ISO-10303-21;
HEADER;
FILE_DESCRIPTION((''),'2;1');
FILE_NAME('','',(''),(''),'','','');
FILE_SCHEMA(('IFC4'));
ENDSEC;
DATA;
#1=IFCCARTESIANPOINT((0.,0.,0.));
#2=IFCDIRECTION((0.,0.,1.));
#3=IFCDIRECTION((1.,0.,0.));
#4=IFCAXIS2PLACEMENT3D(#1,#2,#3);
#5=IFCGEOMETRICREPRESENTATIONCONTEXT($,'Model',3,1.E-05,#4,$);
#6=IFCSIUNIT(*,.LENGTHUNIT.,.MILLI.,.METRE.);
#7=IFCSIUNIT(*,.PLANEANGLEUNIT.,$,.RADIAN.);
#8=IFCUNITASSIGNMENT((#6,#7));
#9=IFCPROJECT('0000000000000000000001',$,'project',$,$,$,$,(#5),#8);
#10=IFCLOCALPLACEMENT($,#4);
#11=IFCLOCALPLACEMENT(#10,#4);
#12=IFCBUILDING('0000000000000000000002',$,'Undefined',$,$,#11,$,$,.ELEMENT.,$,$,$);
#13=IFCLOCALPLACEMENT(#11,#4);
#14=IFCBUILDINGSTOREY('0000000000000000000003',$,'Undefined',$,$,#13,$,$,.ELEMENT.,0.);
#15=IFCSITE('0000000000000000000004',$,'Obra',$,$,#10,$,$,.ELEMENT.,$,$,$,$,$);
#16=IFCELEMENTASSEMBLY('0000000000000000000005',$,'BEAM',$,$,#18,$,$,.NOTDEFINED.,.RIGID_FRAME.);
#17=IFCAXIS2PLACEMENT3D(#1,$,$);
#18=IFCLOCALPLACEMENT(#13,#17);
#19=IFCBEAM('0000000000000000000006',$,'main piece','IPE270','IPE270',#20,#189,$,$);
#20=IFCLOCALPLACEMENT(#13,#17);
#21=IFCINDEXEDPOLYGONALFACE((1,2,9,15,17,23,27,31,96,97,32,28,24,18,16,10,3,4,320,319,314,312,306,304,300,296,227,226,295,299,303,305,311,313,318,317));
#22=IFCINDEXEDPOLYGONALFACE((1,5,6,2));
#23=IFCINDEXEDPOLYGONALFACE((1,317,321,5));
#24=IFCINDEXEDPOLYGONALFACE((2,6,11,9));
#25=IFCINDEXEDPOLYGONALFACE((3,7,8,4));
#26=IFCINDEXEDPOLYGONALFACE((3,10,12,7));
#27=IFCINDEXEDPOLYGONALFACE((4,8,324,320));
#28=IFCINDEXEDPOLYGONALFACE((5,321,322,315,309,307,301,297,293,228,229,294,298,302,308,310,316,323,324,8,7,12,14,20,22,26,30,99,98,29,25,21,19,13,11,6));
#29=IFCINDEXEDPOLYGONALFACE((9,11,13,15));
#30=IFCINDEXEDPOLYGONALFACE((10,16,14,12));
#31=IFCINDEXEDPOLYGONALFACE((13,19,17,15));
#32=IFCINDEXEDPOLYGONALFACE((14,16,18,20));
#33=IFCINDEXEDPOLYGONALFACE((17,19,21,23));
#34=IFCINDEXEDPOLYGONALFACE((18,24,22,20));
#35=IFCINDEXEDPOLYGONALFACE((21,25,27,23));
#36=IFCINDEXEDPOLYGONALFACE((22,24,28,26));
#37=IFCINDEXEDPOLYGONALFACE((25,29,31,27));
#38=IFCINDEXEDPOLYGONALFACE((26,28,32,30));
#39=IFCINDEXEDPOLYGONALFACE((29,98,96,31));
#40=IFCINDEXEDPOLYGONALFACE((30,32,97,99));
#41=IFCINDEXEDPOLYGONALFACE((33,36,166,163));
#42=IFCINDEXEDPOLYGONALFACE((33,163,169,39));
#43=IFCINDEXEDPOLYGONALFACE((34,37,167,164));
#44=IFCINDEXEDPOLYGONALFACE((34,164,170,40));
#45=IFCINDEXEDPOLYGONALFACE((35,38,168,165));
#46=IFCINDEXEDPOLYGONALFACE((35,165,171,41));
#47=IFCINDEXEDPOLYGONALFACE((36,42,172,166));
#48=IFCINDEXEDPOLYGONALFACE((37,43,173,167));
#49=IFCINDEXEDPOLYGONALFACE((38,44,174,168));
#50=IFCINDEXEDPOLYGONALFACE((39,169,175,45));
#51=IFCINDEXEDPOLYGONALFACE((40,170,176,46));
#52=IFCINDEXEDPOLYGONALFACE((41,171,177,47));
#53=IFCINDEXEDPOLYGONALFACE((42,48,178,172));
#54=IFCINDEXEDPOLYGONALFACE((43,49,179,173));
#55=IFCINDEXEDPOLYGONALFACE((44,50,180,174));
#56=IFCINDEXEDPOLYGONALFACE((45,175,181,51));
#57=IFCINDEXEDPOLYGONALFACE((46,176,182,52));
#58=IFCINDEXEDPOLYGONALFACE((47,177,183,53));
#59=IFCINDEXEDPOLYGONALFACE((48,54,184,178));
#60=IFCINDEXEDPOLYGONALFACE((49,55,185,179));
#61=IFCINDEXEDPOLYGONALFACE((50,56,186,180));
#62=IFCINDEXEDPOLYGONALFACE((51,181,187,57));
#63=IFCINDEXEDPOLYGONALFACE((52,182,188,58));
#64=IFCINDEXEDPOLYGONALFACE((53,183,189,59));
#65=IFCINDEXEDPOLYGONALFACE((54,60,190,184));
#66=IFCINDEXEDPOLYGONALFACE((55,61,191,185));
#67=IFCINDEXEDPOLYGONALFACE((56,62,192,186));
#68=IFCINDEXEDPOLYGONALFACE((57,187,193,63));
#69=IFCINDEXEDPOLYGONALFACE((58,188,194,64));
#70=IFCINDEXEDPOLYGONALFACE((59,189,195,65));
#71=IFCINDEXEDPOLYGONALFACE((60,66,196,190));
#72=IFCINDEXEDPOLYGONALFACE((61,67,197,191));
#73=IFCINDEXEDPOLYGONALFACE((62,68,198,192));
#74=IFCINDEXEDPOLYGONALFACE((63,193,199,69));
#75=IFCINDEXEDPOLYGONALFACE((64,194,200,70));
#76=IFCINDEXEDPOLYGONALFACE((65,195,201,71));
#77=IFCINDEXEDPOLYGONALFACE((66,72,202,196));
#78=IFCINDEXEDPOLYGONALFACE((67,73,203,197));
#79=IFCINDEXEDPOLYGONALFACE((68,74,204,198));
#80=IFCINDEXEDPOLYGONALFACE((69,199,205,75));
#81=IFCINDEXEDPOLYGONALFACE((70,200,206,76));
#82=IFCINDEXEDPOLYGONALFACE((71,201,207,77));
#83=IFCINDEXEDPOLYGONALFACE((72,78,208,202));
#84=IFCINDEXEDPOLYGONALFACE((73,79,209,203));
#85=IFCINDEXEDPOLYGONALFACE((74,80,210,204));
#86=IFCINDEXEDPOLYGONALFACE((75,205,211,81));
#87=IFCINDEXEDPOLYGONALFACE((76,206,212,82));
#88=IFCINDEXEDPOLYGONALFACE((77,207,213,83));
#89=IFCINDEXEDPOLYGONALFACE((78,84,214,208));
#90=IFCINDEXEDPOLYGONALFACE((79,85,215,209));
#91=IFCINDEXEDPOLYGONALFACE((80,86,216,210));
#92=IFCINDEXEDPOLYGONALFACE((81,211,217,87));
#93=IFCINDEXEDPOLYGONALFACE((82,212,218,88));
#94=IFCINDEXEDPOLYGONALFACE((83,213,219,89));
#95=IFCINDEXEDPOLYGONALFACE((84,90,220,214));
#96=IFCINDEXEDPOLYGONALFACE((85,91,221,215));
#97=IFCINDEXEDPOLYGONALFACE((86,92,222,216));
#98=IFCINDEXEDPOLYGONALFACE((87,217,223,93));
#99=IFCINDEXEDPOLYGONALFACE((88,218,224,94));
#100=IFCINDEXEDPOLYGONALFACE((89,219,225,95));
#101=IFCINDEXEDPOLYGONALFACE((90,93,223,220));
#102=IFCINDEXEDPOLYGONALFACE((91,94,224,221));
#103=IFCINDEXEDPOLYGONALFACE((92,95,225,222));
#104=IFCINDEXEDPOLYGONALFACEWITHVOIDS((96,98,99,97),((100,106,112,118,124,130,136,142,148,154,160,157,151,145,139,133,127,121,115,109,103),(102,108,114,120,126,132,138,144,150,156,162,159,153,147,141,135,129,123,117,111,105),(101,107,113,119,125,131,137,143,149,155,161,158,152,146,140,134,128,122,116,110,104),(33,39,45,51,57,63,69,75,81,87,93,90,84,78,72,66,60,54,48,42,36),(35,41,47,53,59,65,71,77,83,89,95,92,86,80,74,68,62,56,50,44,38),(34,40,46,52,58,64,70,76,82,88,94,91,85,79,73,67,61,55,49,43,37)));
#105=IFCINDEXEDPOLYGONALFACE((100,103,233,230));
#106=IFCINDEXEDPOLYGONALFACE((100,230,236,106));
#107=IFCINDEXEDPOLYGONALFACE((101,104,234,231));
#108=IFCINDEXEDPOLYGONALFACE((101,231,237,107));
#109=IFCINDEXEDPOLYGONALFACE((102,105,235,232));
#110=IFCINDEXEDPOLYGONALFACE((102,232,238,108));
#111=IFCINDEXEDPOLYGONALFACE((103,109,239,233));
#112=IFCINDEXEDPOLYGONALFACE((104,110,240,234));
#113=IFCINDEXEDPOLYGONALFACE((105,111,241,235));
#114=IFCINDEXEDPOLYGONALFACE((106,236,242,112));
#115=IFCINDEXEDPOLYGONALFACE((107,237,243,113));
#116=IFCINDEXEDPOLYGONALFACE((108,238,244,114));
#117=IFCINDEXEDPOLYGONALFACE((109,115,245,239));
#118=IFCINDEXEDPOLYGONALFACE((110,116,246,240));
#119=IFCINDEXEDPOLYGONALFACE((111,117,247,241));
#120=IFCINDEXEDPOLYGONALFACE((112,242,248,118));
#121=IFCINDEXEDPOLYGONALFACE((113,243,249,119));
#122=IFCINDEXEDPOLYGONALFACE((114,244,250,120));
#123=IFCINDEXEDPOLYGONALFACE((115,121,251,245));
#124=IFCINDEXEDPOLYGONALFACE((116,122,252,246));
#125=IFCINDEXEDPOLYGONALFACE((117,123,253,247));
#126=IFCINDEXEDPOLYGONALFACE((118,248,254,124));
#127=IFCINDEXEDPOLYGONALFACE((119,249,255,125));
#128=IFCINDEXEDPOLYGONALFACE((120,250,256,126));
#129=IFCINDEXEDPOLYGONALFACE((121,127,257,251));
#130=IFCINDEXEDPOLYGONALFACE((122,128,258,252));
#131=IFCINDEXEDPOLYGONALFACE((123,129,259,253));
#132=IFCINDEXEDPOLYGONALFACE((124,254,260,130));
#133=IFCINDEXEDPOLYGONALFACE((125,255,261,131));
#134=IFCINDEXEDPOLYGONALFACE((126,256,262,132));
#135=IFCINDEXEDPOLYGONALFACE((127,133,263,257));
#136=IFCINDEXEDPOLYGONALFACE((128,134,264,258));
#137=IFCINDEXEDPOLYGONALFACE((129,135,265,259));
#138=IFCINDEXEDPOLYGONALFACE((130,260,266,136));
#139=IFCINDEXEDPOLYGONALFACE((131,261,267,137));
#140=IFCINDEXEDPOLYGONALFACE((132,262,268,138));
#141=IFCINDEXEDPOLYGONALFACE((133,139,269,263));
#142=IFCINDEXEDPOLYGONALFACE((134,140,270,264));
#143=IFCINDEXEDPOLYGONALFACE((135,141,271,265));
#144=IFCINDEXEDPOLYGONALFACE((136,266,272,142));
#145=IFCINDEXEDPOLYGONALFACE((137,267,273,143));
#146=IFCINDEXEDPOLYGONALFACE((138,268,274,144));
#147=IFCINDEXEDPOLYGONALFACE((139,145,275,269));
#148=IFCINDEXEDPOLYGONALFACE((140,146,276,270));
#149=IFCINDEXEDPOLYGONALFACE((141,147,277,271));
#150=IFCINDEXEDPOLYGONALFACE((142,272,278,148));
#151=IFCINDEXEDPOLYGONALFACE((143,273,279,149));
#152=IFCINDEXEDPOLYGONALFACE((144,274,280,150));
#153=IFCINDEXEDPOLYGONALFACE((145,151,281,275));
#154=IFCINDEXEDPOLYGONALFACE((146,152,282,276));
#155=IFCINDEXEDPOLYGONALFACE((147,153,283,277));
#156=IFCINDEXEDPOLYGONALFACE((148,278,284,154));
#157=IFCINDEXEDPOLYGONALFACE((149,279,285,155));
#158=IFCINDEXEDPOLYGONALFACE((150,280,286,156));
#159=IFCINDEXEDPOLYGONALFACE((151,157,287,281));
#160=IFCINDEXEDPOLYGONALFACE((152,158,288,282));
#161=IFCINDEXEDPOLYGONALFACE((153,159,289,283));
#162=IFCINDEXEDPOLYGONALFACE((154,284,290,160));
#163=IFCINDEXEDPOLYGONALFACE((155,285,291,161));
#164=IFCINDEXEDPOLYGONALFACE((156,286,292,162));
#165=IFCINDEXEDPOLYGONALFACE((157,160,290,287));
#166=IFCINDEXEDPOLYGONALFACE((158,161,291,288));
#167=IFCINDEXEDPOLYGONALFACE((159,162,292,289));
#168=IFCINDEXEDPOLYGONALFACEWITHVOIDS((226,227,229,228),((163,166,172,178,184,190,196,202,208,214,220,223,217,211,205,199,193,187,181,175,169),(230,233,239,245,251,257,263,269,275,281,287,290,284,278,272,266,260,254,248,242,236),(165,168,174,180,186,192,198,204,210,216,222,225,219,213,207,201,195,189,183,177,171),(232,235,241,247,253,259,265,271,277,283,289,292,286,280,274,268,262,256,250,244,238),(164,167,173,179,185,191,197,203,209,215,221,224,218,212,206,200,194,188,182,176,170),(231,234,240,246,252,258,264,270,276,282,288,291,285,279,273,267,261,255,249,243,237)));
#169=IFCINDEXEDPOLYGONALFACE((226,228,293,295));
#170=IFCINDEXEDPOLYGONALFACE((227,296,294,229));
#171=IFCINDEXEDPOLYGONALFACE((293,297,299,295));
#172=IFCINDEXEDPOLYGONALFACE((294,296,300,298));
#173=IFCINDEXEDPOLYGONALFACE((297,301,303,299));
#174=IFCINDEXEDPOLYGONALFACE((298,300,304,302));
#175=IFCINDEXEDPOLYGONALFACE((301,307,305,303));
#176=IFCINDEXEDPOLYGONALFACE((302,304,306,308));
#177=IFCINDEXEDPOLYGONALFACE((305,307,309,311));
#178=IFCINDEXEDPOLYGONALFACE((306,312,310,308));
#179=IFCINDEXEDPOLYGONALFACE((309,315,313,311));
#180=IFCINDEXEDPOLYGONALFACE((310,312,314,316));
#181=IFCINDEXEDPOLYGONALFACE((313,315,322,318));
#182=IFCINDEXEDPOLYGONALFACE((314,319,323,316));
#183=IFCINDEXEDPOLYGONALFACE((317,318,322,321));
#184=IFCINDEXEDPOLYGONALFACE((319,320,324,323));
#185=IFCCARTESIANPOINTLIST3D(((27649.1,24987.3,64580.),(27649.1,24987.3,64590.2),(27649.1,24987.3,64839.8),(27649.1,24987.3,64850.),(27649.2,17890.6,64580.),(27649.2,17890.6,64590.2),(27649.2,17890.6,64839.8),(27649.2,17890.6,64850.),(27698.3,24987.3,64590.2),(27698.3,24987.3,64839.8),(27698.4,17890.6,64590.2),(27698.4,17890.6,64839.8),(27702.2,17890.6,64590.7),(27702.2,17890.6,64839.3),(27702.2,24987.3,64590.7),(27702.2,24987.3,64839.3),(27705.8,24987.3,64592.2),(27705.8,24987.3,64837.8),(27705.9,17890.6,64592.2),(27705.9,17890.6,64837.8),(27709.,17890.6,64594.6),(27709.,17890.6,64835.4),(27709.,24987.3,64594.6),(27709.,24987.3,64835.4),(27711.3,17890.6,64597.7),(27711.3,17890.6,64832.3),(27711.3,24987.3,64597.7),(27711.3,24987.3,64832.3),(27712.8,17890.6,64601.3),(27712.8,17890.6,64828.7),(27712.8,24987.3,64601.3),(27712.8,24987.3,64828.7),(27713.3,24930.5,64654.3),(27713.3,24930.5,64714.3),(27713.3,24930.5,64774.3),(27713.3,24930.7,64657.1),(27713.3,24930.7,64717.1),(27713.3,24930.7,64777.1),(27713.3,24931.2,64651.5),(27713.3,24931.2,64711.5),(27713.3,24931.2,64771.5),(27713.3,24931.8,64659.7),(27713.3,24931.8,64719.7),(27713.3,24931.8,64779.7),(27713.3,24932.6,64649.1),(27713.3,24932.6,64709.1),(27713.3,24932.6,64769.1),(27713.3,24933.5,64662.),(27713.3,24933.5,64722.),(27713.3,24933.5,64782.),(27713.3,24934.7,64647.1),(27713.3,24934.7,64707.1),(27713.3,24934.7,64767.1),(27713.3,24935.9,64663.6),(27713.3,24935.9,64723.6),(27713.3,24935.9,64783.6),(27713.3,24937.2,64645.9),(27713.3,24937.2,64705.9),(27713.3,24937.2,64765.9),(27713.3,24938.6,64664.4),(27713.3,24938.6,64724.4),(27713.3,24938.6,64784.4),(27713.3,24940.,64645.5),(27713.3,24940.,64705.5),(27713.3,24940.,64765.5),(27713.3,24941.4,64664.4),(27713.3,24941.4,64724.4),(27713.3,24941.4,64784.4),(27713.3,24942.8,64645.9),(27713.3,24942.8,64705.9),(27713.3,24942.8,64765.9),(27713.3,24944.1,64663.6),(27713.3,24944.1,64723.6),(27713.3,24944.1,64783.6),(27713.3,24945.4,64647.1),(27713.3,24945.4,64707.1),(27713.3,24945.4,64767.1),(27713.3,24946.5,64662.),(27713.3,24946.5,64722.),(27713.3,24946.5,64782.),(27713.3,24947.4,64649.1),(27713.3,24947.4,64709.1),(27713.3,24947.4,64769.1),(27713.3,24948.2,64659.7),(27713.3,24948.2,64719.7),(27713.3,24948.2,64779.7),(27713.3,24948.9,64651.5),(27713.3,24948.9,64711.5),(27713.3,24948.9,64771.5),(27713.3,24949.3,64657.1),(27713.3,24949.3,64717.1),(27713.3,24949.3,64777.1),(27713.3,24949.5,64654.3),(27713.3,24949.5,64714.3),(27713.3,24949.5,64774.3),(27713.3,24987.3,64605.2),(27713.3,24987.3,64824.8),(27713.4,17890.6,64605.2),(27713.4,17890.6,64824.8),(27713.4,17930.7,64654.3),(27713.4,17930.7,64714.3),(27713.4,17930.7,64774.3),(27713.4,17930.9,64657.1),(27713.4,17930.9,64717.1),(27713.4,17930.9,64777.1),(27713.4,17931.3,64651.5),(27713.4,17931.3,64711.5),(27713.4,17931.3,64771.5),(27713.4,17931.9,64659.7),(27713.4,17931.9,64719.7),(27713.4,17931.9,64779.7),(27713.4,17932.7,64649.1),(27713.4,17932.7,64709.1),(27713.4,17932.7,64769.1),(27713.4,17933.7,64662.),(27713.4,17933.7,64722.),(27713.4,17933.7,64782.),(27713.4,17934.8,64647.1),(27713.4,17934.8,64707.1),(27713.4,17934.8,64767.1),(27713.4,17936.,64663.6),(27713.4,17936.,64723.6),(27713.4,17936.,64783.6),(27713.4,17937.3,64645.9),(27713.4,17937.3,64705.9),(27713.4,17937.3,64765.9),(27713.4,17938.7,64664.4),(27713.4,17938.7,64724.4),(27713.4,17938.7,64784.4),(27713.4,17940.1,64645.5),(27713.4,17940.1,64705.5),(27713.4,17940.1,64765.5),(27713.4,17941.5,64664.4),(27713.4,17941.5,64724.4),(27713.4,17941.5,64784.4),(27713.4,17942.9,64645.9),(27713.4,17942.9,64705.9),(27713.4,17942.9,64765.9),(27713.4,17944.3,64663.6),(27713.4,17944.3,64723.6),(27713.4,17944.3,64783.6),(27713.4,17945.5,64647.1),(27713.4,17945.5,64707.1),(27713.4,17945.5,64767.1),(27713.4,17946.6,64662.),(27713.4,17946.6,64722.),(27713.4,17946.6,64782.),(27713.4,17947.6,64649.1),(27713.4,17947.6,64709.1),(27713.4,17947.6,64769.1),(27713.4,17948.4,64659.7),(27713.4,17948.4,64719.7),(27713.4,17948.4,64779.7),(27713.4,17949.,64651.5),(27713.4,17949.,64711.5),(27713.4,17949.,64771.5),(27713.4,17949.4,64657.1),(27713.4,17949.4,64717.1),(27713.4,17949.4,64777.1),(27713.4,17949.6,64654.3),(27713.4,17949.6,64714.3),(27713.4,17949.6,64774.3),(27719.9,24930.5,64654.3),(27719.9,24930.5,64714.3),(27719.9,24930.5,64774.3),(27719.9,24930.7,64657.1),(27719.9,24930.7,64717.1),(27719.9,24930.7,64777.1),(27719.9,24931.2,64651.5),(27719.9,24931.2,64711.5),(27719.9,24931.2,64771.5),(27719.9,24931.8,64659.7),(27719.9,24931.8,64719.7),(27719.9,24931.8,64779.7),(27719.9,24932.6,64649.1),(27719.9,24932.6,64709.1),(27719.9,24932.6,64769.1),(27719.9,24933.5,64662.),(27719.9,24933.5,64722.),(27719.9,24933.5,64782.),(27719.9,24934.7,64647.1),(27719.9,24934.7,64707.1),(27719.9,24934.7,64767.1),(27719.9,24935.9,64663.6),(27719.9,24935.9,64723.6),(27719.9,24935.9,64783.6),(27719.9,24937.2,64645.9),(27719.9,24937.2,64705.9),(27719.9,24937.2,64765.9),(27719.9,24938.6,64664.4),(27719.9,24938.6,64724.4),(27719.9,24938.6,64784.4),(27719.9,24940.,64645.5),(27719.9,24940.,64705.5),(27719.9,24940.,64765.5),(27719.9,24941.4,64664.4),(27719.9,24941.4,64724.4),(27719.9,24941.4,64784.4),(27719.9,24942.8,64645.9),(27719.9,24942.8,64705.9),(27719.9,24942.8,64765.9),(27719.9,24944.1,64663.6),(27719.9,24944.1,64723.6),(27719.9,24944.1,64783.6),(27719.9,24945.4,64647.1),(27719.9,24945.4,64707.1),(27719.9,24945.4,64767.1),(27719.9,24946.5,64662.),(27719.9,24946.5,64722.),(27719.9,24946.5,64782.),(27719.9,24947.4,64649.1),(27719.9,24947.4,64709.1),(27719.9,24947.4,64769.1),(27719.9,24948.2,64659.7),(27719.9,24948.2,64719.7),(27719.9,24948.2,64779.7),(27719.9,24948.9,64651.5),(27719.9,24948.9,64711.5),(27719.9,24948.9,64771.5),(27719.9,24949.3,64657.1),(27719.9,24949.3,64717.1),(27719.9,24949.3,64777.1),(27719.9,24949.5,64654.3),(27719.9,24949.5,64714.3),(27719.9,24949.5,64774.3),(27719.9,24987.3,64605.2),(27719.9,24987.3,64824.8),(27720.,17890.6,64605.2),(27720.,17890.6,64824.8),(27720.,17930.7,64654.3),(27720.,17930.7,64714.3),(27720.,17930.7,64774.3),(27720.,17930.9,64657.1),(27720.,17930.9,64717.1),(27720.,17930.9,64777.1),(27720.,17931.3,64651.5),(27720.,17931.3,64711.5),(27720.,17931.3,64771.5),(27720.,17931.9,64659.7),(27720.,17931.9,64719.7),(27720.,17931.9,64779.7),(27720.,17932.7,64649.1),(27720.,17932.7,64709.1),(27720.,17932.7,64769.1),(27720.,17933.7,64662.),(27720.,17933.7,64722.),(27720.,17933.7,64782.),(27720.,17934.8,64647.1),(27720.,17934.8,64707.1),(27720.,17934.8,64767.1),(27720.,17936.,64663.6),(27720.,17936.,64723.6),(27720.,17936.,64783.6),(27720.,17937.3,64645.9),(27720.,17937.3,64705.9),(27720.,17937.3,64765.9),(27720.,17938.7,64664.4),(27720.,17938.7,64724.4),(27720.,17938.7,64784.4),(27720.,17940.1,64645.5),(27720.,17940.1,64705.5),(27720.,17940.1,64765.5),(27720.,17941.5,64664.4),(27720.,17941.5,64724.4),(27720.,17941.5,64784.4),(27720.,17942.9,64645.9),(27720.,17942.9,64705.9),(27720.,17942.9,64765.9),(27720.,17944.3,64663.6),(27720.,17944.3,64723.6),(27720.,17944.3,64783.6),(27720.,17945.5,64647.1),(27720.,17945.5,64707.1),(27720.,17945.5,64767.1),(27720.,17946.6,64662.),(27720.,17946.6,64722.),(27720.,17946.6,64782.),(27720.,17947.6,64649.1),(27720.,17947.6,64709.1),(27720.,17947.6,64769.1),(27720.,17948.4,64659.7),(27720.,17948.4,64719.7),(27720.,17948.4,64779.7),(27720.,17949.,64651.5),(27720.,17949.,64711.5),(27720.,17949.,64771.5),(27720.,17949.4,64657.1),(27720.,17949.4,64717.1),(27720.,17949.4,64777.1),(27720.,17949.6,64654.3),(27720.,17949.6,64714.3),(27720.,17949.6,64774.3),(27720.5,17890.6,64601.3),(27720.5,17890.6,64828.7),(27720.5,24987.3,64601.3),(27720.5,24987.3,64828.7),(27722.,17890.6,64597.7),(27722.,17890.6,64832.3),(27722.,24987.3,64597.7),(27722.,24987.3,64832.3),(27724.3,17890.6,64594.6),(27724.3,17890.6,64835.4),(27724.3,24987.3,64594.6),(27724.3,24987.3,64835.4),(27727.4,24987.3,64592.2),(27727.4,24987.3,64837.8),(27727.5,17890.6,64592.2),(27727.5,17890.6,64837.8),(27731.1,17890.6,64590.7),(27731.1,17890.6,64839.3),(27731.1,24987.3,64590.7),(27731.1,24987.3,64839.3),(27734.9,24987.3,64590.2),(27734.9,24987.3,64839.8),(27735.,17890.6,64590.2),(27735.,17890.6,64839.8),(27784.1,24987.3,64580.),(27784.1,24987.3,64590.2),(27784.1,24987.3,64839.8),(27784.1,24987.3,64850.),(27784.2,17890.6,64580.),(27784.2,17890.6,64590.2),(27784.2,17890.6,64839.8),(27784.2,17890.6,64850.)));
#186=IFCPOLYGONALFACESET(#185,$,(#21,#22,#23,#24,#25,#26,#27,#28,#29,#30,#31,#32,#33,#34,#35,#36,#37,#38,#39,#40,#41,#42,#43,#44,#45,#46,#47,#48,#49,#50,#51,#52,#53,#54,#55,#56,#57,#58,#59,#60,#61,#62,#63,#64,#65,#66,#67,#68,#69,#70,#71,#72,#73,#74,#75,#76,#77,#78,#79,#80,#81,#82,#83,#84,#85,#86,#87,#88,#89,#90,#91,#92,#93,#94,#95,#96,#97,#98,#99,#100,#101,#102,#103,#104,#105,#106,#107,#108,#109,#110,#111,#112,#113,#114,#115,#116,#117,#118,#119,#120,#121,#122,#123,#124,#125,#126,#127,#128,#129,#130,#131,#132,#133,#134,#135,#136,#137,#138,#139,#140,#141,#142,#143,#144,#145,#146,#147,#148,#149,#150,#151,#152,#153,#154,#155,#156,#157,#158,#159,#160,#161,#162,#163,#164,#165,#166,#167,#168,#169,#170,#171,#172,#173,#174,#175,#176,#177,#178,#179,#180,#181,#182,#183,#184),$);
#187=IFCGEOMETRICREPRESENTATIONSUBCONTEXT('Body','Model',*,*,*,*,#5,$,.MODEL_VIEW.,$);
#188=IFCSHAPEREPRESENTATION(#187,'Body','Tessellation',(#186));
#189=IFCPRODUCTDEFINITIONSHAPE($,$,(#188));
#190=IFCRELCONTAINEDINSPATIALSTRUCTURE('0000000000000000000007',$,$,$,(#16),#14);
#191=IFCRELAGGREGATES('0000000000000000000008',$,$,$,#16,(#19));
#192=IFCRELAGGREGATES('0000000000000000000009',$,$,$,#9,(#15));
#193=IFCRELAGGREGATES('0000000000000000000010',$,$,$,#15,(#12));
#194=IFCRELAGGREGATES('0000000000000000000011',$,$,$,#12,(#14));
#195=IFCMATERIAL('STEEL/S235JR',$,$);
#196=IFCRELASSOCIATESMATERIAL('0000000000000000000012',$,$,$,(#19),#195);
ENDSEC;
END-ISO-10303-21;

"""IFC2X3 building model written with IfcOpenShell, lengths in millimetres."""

from ifc_helpers import new_model, si_unit, frame, origin_with_axes, origin_2d_with_axis, place, context, subcontext, project, spatial, circle, i_section, extrude, clip, halfspace, source, transform, mapped, material, element, aggregate, save


model = new_model("IFC2X3")

# Units and contexts
model_context = context("Model", 3, precision=1e-05, world=origin_with_axes())
body_context = subcontext(model_context, "Body", "Model", "MODEL_VIEW")
ifc_project = project(units=[si_unit("LENGTHUNIT", "METRE", prefix="MILLI"), si_unit("PLANEANGLEUNIT", "RADIAN")], contexts=[model_context])

# Site, building, storey
site_placement = place(None, origin_with_axes())
site = spatial("IfcSite", under=ifc_project, at=site_placement, Name="Obra", CompositionType="ELEMENT")
building_placement = place(site_placement, origin_with_axes())
building = spatial("IfcBuilding", under=site, at=building_placement, Name="Undefined", CompositionType="ELEMENT")
storey_placement = place(building_placement, origin_with_axes())
storey = spatial("IfcBuildingStorey", under=building, at=storey_placement, Name="Undefined", CompositionType="ELEMENT", Elevation=0.0)

# Shared definitions
ifc_material_1 = material(Name="STEEL/S235JR")

# Element assembly, beam, openings
assembly_1_placement = place(storey_placement, origin_with_axes())
assembly_1 = element("IfcElementAssembly", 1, at=assembly_1_placement, inside=storey, Name="BEAM", AssemblyPlace="NOTDEFINED", PredefinedType="RIGID_FRAME")
beam_1_placement = place(assembly_1_placement, frame((27716.7, 17630.1, 64715.0), z_axis=(0.0, 0.0, 1.0), x_axis=(-0.000002, 1.0, 0.0)))
beam_1 = element("IfcBeam", 2, at=beam_1_placement, material=ifc_material_1, Name="main piece", Description="IPE270", ObjectType="IPE270", context=body_context, shape_type="Clipping", body=[
    clip(clip(extrude(i_section(OverallWidth=135.0, OverallDepth=270.0, WebThickness=6.6, FlangeThickness=10.2, FilletRadius=15.0, at=origin_2d_with_axis()), frame((7357.1, 0.0, 0.0), z_axis=(-1.0, 0.0, 0.0), x_axis=(0.0, -1.0, 0.0)), (0.0, 0.0, 1.0), 7357.1), halfspace(frame((260.5, 60.0, -120.0), z_axis=(-1.0, -0.000017, 0.0), x_axis=(0.0, 0.0, 1.0)), False)), halfspace(frame((7359.4, -60.0, -120.0), z_axis=(1.0, 0.000019, 0.0), x_axis=(0.0, 0.0, 1.0)), False)),
])
shared_shape_1 = source(origin_with_axes(), body_context, "Body", "SweptSolid", [
    extrude(circle(Radius=9.5, at=origin_2d_with_axis()), frame((0.0, -3.4, 0.0), z_axis=(0.0, 1.0, 0.0), x_axis=(1.0, 0.0, 0.0)), (0.0, 0.0, 1.0), 6.8),
])
opening_1_placement = place(assembly_1_placement, frame((27716.7, 17890.1, 64835.0), z_axis=(0.0, 1.0, 0.0), x_axis=(0.0, 0.0, -1.0)))
element("IfcOpeningElement", 3, at=opening_1_placement, cuts=beam_1, ObjectType="Opening", context=body_context, shape_type="MappedRepresentation", body=[
    mapped(shared_shape_1, transform((60.0, 0.0, 50.0))),
    mapped(shared_shape_1, transform((120.0, 0.0, 50.0))),
    mapped(shared_shape_1, transform((180.0, 0.0, 50.0))),
])
shared_shape_2 = source(origin_with_axes(), body_context, "Body", "SweptSolid", [
    extrude(circle(Radius=9.5, at=origin_2d_with_axis()), frame((0.0, -3.4, 0.0), z_axis=(0.0, 1.0, 0.0), x_axis=(1.0, 0.0, 0.0)), (0.0, 0.0, 1.0), 6.8),
])
opening_2_placement = place(assembly_1_placement, frame((27716.6, 24990.0, 64835.0), z_axis=(0.000002, -1.0, 0.0), x_axis=(0.0, 0.0, -1.0)))
element("IfcOpeningElement", 4, at=opening_2_placement, cuts=beam_1, ObjectType="Opening", context=body_context, shape_type="MappedRepresentation", body=[
    mapped(shared_shape_2, transform((60.0, 0.0, 50.0))),
    mapped(shared_shape_2, transform((120.0, 0.0, 50.0))),
    mapped(shared_shape_2, transform((180.0, 0.0, 50.0))),
])
aggregate(assembly_1, [beam_1])

save(model, "model.ifc")
